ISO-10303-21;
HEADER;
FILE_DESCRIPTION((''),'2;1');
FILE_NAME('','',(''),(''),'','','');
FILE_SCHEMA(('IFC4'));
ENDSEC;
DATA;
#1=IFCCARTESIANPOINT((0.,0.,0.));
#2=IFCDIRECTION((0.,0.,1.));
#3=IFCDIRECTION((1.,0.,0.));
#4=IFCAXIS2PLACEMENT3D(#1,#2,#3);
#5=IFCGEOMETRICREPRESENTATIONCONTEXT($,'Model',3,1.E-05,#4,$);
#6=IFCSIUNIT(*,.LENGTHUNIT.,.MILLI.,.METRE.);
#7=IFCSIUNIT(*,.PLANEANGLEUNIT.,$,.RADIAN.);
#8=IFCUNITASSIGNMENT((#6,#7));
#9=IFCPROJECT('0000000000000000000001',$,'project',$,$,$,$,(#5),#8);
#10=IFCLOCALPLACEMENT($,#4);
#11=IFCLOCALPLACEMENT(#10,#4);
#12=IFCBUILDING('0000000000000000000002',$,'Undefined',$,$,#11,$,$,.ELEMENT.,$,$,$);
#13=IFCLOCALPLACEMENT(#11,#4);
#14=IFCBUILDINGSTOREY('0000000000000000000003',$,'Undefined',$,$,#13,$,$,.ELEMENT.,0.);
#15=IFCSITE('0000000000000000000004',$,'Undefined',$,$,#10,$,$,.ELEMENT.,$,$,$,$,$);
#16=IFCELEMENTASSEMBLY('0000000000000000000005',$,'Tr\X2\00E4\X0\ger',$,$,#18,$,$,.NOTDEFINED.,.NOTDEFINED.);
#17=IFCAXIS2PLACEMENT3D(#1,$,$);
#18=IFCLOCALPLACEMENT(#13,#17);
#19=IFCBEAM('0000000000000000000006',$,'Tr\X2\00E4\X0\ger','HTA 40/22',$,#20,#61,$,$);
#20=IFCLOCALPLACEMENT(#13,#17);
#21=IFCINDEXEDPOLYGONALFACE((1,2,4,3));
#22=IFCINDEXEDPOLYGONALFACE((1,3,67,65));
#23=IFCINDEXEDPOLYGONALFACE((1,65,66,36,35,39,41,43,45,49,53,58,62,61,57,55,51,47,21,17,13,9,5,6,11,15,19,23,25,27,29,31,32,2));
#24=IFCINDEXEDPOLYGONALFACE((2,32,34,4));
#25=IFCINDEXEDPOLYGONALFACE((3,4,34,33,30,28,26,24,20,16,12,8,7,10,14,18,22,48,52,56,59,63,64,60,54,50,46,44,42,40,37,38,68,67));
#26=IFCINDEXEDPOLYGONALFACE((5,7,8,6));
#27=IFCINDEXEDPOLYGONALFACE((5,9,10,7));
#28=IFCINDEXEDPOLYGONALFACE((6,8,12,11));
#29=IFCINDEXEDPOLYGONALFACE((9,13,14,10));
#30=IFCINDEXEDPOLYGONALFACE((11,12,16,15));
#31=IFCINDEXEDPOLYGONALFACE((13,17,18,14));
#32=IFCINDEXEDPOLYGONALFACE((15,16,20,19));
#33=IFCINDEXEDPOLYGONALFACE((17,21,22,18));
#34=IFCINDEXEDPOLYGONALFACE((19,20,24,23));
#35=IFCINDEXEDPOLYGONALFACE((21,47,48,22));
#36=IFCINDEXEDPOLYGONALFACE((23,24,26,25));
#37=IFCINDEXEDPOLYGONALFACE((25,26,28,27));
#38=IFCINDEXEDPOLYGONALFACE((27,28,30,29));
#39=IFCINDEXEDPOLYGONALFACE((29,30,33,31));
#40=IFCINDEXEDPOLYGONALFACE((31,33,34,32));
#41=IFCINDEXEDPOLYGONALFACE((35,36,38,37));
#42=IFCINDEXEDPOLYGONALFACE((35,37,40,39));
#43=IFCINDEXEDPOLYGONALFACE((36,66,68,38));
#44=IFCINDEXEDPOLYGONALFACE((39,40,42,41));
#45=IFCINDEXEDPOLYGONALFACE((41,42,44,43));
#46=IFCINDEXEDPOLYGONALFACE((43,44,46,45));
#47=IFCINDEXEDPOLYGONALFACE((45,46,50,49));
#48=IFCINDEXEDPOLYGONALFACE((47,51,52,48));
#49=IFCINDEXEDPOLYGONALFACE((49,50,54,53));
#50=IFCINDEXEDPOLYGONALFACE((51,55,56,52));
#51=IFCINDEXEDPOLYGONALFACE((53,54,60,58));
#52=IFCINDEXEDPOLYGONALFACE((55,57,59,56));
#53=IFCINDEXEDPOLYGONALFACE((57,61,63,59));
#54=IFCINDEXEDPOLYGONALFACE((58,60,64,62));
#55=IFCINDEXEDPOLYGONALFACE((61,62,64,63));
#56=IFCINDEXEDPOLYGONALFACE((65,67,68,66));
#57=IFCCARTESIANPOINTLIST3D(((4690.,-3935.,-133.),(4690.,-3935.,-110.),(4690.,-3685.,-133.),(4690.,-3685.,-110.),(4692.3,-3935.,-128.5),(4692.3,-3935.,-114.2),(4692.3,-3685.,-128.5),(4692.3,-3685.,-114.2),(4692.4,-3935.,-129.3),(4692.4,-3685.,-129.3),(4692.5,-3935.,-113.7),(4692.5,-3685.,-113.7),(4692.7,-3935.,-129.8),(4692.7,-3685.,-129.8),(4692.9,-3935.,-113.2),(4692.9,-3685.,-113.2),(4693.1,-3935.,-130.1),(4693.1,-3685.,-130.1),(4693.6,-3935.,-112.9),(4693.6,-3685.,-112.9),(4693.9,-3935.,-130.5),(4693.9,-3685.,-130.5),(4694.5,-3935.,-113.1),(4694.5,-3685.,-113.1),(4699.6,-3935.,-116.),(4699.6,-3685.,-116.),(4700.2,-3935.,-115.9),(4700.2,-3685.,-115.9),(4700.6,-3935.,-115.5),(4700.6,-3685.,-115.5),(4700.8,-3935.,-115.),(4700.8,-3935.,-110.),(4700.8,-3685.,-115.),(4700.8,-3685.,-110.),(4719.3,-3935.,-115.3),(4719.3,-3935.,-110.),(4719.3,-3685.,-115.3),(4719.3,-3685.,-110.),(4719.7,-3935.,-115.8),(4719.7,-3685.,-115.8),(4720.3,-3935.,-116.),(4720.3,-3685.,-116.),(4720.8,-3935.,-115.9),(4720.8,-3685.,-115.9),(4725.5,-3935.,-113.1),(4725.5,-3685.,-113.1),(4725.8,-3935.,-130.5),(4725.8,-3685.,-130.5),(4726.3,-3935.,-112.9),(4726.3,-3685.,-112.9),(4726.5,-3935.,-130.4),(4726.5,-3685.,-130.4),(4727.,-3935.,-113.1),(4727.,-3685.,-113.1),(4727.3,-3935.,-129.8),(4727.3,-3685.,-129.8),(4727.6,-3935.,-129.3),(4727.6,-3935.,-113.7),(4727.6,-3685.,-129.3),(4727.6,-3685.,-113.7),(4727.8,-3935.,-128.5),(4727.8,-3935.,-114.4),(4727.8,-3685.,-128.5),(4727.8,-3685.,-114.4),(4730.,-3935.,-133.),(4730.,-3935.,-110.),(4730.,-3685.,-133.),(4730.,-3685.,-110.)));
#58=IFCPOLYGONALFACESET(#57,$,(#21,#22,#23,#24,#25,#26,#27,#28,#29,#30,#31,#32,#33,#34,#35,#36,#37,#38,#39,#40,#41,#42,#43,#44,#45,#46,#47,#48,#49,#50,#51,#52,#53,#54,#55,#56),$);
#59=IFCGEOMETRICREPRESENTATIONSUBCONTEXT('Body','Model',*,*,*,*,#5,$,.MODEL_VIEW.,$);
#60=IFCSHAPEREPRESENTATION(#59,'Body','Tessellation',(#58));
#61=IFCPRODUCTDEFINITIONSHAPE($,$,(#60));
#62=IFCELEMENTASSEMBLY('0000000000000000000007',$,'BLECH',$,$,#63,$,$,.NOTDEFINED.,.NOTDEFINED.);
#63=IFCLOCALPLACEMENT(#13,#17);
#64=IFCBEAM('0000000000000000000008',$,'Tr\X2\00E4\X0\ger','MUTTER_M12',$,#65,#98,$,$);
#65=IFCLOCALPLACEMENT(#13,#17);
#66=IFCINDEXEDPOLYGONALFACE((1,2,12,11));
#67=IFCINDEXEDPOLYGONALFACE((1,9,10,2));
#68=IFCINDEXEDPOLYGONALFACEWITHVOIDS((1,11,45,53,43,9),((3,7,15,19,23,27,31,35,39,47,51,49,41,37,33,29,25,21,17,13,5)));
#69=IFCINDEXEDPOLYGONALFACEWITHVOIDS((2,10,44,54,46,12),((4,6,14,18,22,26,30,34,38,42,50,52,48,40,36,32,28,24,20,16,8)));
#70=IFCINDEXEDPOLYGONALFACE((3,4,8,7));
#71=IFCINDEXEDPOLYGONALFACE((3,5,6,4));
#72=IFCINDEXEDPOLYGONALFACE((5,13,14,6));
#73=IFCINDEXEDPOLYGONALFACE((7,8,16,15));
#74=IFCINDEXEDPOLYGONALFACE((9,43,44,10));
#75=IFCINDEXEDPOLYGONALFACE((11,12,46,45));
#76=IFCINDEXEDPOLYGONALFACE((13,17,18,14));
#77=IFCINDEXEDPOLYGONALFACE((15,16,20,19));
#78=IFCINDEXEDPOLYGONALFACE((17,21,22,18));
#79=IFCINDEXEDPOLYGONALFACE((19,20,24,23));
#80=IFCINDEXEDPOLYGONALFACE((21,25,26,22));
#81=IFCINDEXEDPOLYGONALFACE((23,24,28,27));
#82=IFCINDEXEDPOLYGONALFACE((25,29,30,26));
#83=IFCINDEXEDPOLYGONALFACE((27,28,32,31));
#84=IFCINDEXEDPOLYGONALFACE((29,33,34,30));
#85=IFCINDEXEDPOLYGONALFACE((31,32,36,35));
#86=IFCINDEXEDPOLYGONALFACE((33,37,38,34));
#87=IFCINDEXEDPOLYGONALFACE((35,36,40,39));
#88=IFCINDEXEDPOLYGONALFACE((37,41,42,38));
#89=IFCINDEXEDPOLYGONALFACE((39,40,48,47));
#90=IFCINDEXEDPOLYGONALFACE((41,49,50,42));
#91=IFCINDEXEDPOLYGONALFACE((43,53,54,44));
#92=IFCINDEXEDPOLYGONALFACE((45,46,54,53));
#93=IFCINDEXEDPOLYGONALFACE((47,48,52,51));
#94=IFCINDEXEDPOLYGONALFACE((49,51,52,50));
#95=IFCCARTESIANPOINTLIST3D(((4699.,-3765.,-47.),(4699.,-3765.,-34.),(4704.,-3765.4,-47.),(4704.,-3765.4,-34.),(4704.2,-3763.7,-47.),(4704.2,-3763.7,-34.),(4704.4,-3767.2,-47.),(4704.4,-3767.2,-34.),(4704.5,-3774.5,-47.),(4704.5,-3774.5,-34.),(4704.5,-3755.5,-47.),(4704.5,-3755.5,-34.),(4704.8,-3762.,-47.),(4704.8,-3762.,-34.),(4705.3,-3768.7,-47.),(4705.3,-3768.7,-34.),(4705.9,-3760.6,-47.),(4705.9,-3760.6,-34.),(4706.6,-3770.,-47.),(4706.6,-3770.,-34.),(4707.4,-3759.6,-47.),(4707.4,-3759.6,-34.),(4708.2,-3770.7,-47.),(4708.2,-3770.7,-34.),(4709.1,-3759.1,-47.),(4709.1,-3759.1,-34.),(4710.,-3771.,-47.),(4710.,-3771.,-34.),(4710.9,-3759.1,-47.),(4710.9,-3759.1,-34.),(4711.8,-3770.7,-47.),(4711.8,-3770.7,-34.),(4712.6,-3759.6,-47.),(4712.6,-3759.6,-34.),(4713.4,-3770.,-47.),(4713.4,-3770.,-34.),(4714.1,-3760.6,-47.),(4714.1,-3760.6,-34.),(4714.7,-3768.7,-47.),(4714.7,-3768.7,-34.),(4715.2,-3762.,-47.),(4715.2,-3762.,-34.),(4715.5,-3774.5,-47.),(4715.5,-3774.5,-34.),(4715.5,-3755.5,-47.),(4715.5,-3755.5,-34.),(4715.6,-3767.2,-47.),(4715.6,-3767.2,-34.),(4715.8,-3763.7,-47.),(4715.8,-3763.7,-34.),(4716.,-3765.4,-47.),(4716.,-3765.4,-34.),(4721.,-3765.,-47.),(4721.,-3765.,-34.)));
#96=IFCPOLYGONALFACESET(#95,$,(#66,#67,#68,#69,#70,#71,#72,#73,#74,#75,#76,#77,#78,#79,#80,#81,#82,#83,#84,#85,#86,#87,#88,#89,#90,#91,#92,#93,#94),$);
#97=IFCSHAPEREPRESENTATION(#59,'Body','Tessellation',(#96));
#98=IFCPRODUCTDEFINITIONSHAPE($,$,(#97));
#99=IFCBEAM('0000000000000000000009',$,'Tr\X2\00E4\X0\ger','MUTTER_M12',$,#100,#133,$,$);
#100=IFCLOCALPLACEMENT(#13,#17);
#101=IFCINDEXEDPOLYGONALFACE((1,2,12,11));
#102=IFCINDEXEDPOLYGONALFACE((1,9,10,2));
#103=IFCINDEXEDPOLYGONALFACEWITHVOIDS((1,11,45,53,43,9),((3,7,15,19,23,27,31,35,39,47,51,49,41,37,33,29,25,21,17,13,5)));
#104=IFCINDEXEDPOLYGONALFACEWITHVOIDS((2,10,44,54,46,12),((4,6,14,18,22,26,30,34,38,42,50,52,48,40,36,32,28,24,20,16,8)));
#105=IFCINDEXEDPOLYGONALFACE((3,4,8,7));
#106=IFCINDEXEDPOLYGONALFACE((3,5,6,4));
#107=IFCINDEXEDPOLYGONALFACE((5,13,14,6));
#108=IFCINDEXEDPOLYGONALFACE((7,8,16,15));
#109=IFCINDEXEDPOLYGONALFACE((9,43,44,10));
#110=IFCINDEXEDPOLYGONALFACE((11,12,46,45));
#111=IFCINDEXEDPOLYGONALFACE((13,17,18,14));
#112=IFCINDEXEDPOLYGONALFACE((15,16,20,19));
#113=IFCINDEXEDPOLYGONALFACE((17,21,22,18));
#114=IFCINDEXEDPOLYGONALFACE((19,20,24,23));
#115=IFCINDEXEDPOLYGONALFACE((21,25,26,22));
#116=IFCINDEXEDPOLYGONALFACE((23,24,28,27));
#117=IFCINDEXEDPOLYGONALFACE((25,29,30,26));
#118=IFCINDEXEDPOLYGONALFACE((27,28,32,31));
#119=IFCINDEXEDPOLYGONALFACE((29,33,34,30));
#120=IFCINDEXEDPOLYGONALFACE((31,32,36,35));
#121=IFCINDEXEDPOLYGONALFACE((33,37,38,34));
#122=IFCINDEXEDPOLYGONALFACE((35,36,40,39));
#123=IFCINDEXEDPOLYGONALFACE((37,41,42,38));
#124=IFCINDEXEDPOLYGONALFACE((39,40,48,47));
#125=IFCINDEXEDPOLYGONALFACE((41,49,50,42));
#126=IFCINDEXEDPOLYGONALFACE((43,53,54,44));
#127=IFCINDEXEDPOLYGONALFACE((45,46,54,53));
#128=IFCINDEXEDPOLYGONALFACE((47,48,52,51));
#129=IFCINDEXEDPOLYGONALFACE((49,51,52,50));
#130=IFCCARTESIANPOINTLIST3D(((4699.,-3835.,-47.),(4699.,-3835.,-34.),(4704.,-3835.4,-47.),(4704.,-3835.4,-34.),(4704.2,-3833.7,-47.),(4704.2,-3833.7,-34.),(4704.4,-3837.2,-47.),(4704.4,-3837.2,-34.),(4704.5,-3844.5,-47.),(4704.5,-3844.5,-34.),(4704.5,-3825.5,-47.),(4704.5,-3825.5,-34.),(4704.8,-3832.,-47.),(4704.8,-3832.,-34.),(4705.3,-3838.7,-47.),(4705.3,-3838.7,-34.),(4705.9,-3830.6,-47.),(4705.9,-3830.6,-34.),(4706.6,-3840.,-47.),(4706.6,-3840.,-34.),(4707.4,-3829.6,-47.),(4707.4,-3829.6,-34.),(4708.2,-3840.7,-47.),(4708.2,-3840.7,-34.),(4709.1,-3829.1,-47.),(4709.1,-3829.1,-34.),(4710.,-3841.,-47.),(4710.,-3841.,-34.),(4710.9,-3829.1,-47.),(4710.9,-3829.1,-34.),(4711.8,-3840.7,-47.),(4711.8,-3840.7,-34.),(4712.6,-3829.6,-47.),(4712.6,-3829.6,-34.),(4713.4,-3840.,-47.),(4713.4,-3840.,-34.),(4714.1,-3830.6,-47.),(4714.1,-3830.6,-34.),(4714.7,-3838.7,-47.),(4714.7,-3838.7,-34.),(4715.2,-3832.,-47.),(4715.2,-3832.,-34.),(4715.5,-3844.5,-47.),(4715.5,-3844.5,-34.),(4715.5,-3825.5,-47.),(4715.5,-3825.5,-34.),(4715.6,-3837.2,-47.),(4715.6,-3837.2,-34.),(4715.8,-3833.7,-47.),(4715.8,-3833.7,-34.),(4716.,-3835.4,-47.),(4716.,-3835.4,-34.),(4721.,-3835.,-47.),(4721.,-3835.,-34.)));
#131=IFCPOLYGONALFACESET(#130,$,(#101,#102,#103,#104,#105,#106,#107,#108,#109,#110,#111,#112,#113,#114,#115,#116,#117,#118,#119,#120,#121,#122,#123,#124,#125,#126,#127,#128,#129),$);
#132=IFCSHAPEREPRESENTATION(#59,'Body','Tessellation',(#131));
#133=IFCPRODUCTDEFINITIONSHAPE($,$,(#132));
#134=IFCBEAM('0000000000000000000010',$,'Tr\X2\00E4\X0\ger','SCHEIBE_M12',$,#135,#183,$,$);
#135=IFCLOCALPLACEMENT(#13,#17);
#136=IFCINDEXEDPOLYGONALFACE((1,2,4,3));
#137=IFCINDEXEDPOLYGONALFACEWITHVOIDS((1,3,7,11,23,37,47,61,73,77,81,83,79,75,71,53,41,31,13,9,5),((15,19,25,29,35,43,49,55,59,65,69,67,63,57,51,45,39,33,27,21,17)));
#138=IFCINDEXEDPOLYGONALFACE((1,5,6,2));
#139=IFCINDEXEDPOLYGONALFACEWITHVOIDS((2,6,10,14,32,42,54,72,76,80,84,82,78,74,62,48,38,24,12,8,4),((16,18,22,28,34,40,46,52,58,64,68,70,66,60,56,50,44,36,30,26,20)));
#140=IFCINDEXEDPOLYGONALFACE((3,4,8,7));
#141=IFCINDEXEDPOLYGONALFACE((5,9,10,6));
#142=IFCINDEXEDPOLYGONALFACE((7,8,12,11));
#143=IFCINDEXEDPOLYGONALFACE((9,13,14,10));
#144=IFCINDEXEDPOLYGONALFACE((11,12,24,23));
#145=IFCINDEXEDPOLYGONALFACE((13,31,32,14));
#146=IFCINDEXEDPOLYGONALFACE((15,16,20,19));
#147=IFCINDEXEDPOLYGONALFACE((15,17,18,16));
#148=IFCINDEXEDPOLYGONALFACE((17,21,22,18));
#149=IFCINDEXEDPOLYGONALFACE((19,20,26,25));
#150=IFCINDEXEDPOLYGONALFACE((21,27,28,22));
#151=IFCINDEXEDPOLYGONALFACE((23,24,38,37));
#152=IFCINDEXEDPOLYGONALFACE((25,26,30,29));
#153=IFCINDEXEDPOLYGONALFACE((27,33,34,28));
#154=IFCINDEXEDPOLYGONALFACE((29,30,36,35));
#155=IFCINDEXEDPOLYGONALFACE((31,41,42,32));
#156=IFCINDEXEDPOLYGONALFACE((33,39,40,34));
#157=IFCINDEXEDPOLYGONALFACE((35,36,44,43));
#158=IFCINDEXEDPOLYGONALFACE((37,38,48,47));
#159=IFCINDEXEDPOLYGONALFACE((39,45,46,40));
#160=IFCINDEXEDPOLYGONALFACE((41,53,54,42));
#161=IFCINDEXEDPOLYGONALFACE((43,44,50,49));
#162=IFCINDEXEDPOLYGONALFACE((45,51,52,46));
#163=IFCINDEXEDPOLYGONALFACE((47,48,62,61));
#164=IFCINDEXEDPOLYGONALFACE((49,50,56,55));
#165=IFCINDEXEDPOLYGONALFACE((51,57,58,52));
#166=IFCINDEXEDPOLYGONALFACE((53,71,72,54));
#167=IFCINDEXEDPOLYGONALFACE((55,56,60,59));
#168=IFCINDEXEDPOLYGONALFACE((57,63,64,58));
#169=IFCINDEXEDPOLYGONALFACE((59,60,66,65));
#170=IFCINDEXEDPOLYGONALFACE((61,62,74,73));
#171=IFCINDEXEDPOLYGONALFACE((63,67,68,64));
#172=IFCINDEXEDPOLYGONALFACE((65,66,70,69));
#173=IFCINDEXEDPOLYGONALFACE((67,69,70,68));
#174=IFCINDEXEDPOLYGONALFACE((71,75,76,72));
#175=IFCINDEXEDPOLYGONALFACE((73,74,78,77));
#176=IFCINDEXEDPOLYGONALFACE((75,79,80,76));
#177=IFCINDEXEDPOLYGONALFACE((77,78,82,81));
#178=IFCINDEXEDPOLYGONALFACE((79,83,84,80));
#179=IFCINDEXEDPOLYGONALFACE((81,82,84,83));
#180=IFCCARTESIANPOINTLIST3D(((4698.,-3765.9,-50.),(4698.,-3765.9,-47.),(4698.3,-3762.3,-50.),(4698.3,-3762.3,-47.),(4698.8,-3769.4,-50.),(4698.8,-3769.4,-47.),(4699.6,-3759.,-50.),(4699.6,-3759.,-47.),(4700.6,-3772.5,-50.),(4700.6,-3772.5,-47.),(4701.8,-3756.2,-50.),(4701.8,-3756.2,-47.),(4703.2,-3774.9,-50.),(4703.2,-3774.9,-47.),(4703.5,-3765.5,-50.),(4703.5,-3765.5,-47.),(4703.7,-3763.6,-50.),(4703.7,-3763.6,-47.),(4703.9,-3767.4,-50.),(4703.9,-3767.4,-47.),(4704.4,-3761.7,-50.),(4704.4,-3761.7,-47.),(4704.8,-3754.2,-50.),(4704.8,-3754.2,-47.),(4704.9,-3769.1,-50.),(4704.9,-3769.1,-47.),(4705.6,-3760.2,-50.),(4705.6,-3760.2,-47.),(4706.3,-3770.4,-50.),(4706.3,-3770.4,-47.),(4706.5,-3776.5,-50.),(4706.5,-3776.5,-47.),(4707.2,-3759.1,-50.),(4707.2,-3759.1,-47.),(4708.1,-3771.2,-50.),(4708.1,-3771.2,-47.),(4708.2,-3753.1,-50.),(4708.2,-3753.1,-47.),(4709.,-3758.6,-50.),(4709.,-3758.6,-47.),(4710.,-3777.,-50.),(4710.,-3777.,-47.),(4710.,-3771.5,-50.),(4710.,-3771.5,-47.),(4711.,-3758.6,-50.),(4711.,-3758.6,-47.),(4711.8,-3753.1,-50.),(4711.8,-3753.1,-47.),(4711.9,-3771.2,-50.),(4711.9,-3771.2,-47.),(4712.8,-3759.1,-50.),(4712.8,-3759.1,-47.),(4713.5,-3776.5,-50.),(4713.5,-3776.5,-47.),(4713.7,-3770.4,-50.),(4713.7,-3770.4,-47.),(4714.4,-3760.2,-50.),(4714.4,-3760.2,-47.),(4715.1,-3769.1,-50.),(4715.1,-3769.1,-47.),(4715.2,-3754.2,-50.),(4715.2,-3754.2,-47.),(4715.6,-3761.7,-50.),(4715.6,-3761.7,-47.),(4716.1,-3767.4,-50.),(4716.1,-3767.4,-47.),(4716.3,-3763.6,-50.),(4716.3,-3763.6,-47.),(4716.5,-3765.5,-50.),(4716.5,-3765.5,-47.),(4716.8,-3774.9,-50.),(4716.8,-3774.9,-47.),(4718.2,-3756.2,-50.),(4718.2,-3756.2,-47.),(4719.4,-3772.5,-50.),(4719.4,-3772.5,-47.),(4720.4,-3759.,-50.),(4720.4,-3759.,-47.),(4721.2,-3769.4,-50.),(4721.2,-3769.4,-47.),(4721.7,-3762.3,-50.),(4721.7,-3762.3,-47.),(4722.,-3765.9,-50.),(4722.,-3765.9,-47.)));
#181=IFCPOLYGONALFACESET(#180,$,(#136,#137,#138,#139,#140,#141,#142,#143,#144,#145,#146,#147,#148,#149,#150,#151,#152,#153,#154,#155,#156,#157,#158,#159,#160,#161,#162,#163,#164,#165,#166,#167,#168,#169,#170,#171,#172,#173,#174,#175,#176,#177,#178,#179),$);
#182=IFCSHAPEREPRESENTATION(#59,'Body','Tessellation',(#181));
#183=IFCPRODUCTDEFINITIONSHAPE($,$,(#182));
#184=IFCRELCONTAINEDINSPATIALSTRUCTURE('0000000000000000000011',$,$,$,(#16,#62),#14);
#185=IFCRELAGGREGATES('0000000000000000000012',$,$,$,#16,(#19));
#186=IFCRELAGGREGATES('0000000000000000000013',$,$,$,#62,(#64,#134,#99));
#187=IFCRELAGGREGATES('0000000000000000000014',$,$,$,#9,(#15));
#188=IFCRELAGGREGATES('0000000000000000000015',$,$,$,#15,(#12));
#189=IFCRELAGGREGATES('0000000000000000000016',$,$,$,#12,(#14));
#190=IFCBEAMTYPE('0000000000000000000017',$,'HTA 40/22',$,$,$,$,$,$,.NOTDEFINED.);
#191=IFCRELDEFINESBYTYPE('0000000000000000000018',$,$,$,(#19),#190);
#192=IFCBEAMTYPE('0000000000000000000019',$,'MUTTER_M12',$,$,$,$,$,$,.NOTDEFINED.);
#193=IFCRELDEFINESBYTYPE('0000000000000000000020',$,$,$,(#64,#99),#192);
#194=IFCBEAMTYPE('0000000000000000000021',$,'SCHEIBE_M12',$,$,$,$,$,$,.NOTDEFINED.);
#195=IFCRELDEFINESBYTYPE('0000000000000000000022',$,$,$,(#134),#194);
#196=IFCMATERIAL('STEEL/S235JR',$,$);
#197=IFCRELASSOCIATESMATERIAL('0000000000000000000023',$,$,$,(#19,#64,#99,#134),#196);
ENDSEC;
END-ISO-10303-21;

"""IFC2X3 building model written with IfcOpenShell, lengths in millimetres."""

from ifc_helpers import new_model, si_unit, frame, origin_with_axes, origin_2d_with_axis, place, context, subcontext, project, spatial, polyline, circle, hollow_circle, outline, extrude, boolean, material, type_object, element, aggregate, save


model = new_model("IFC2X3")

# Units and contexts
model_context = context("Model", 3, precision=1e-05, world=origin_with_axes())
body_context = subcontext(model_context, "Body", "Model", "MODEL_VIEW")
ifc_project = project(units=[si_unit("LENGTHUNIT", "METRE", prefix="MILLI"), si_unit("PLANEANGLEUNIT", "RADIAN")], contexts=[model_context])

# Site, building, storey
site_placement = place(None, origin_with_axes())
site = spatial("IfcSite", under=ifc_project, at=site_placement, Name="Undefined", CompositionType="ELEMENT")
building_placement = place(site_placement, origin_with_axes())
building = spatial("IfcBuilding", under=site, at=building_placement, Name="Undefined", CompositionType="ELEMENT")
storey_placement = place(building_placement, origin_with_axes())
storey = spatial("IfcBuildingStorey", under=building, at=storey_placement, Name="Undefined", CompositionType="ELEMENT", Elevation=0.0)

# Element assembly, beam
assembly_1_placement = place(storey_placement, origin_with_axes())
assembly_1 = element("IfcElementAssembly", 1, at=assembly_1_placement, inside=storey, Name="Träger", AssemblyPlace="NOTDEFINED", PredefinedType="NOTDEFINED")
ifc_material_1 = material(Name="STEEL/S235JR")
beam_type_1 = type_object("IfcBeamType", Name="HTA 40/22", PredefinedType="NOTDEFINED")
beam_1_placement = place(assembly_1_placement, frame((4710.0, -3935.0, -121.5), z_axis=(0.0, 0.0, -1.0), x_axis=(0.0, 1.0, 0.0)))
beam_1 = element("IfcBeam", 2, at=beam_1_placement, type_object=beam_type_1, material=ifc_material_1, Name="Träger", Description="HTA 40/22", context=body_context, shape_type="SweptSolid", body=[
    extrude(outline(polyline([(-9.3, -6.2), (-9.2, -11.5), (-20.0, -11.5), (-20.0, 11.5), (20.0, 11.5), (20.0, -11.5), (9.2, -11.5), (9.2, -6.5), (9.4, -6.0), (9.8, -5.6), (10.4, -5.5), (15.5, -8.4), (16.4, -8.6), (17.1, -8.3), (17.5, -7.8), (17.7, -7.3), (17.8, 7.0), (17.6, 7.8), (17.3, 8.3), (16.9, 8.6), (16.1, 9.0), (-15.8, 9.0), (-16.5, 8.9), (-17.3, 8.3), (-17.6, 7.8), (-17.8, 7.0), (-17.8, -7.1), (-17.5, -7.8), (-17.0, -8.4), (-16.2, -8.6), (-15.5, -8.4), (-10.8, -5.6), (-10.2, -5.5), (-9.7, -5.7), (-9.3, -6.2)])), frame((250.0, 0.0, 0.0), z_axis=(-1.0, 0.0, 0.0), x_axis=(0.0, -1.0, 0.0)), (0.0, 0.0, 1.0), 250.0),
])
aggregate(assembly_1, [beam_1])

# Element assembly, beams
assembly_2_placement = place(storey_placement, origin_with_axes())
assembly_2 = element("IfcElementAssembly", 3, at=assembly_2_placement, inside=storey, Name="BLECH", AssemblyPlace="NOTDEFINED", PredefinedType="NOTDEFINED")
beam_type_2 = type_object("IfcBeamType", Name="MUTTER_M12", PredefinedType="NOTDEFINED")
beam_2_placement = place(assembly_2_placement, frame((4710.0, -3765.0, -34.0), z_axis=(1.0, 0.0, 0.0), x_axis=(0.0, 0.0, -1.0)))
beam_2 = element("IfcBeam", 4, at=beam_2_placement, type_object=beam_type_2, material=ifc_material_1, Name="Träger", Description="MUTTER_M12", context=body_context, shape_type="CSG", body=[
    boolean("DIFFERENCE", extrude(outline(polyline([(9.5, 5.5), (9.5, -5.5), (0.0, -11.0), (-9.5, -5.5), (-9.5, 5.5), (0.0, 11.0), (9.5, 5.5)])), frame((13.0, 0.0, 0.0), z_axis=(-1.0, 0.0, 0.0), x_axis=(0.0, -1.0, 0.0)), (0.0, 0.0, 1.0), 13.0), extrude(circle(Radius=6.0, at=origin_2d_with_axis()), frame((36.0, 0.0, 0.0), z_axis=(-1.0, 0.0, 0.0), x_axis=(0.0, -1.0, 0.0)), (0.0, 0.0, 1.0), 60.0)),
])
beam_3_placement = place(assembly_2_placement, frame((4710.0, -3835.0, -34.0), z_axis=(1.0, 0.0, 0.0), x_axis=(0.0, 0.0, -1.0)))
beam_3 = element("IfcBeam", 5, at=beam_3_placement, type_object=beam_type_2, material=ifc_material_1, Name="Träger", Description="MUTTER_M12", context=body_context, shape_type="CSG", body=[
    boolean("DIFFERENCE", extrude(outline(polyline([(9.5, 5.5), (9.5, -5.5), (0.0, -11.0), (-9.5, -5.5), (-9.5, 5.5), (0.0, 11.0), (9.5, 5.5)])), frame((13.0, 0.0, 0.0), z_axis=(-1.0, 0.0, 0.0), x_axis=(0.0, -1.0, 0.0)), (0.0, 0.0, 1.0), 13.0), extrude(circle(Radius=6.0, at=origin_2d_with_axis()), frame((36.0, 0.0, 0.0), z_axis=(-1.0, 0.0, 0.0), x_axis=(0.0, -1.0, 0.0)), (0.0, 0.0, 1.0), 60.0)),
])
beam_type_3 = type_object("IfcBeamType", Name="SCHEIBE_M12", PredefinedType="NOTDEFINED")
beam_4_placement = place(assembly_2_placement, frame((4710.0, -3765.0, -47.0), z_axis=(1.0, 0.0, 0.0), x_axis=(0.0, 0.0, -1.0)))
beam_4 = element("IfcBeam", 6, at=beam_4_placement, type_object=beam_type_3, material=ifc_material_1, Name="Träger", Description="SCHEIBE_M12", context=body_context, shape_type="SweptSolid", body=[
    extrude(hollow_circle(Radius=12.0, WallThickness=5.5, at=origin_2d_with_axis()), frame((3.0, 0.0, 0.0), z_axis=(-1.0, 0.0, 0.0), x_axis=(0.0, -1.0, 0.0)), (0.0, 0.0, 1.0), 3.0),
])

aggregate(assembly_2, [beam_2, beam_4, beam_3])

save(model, "model.ifc")
